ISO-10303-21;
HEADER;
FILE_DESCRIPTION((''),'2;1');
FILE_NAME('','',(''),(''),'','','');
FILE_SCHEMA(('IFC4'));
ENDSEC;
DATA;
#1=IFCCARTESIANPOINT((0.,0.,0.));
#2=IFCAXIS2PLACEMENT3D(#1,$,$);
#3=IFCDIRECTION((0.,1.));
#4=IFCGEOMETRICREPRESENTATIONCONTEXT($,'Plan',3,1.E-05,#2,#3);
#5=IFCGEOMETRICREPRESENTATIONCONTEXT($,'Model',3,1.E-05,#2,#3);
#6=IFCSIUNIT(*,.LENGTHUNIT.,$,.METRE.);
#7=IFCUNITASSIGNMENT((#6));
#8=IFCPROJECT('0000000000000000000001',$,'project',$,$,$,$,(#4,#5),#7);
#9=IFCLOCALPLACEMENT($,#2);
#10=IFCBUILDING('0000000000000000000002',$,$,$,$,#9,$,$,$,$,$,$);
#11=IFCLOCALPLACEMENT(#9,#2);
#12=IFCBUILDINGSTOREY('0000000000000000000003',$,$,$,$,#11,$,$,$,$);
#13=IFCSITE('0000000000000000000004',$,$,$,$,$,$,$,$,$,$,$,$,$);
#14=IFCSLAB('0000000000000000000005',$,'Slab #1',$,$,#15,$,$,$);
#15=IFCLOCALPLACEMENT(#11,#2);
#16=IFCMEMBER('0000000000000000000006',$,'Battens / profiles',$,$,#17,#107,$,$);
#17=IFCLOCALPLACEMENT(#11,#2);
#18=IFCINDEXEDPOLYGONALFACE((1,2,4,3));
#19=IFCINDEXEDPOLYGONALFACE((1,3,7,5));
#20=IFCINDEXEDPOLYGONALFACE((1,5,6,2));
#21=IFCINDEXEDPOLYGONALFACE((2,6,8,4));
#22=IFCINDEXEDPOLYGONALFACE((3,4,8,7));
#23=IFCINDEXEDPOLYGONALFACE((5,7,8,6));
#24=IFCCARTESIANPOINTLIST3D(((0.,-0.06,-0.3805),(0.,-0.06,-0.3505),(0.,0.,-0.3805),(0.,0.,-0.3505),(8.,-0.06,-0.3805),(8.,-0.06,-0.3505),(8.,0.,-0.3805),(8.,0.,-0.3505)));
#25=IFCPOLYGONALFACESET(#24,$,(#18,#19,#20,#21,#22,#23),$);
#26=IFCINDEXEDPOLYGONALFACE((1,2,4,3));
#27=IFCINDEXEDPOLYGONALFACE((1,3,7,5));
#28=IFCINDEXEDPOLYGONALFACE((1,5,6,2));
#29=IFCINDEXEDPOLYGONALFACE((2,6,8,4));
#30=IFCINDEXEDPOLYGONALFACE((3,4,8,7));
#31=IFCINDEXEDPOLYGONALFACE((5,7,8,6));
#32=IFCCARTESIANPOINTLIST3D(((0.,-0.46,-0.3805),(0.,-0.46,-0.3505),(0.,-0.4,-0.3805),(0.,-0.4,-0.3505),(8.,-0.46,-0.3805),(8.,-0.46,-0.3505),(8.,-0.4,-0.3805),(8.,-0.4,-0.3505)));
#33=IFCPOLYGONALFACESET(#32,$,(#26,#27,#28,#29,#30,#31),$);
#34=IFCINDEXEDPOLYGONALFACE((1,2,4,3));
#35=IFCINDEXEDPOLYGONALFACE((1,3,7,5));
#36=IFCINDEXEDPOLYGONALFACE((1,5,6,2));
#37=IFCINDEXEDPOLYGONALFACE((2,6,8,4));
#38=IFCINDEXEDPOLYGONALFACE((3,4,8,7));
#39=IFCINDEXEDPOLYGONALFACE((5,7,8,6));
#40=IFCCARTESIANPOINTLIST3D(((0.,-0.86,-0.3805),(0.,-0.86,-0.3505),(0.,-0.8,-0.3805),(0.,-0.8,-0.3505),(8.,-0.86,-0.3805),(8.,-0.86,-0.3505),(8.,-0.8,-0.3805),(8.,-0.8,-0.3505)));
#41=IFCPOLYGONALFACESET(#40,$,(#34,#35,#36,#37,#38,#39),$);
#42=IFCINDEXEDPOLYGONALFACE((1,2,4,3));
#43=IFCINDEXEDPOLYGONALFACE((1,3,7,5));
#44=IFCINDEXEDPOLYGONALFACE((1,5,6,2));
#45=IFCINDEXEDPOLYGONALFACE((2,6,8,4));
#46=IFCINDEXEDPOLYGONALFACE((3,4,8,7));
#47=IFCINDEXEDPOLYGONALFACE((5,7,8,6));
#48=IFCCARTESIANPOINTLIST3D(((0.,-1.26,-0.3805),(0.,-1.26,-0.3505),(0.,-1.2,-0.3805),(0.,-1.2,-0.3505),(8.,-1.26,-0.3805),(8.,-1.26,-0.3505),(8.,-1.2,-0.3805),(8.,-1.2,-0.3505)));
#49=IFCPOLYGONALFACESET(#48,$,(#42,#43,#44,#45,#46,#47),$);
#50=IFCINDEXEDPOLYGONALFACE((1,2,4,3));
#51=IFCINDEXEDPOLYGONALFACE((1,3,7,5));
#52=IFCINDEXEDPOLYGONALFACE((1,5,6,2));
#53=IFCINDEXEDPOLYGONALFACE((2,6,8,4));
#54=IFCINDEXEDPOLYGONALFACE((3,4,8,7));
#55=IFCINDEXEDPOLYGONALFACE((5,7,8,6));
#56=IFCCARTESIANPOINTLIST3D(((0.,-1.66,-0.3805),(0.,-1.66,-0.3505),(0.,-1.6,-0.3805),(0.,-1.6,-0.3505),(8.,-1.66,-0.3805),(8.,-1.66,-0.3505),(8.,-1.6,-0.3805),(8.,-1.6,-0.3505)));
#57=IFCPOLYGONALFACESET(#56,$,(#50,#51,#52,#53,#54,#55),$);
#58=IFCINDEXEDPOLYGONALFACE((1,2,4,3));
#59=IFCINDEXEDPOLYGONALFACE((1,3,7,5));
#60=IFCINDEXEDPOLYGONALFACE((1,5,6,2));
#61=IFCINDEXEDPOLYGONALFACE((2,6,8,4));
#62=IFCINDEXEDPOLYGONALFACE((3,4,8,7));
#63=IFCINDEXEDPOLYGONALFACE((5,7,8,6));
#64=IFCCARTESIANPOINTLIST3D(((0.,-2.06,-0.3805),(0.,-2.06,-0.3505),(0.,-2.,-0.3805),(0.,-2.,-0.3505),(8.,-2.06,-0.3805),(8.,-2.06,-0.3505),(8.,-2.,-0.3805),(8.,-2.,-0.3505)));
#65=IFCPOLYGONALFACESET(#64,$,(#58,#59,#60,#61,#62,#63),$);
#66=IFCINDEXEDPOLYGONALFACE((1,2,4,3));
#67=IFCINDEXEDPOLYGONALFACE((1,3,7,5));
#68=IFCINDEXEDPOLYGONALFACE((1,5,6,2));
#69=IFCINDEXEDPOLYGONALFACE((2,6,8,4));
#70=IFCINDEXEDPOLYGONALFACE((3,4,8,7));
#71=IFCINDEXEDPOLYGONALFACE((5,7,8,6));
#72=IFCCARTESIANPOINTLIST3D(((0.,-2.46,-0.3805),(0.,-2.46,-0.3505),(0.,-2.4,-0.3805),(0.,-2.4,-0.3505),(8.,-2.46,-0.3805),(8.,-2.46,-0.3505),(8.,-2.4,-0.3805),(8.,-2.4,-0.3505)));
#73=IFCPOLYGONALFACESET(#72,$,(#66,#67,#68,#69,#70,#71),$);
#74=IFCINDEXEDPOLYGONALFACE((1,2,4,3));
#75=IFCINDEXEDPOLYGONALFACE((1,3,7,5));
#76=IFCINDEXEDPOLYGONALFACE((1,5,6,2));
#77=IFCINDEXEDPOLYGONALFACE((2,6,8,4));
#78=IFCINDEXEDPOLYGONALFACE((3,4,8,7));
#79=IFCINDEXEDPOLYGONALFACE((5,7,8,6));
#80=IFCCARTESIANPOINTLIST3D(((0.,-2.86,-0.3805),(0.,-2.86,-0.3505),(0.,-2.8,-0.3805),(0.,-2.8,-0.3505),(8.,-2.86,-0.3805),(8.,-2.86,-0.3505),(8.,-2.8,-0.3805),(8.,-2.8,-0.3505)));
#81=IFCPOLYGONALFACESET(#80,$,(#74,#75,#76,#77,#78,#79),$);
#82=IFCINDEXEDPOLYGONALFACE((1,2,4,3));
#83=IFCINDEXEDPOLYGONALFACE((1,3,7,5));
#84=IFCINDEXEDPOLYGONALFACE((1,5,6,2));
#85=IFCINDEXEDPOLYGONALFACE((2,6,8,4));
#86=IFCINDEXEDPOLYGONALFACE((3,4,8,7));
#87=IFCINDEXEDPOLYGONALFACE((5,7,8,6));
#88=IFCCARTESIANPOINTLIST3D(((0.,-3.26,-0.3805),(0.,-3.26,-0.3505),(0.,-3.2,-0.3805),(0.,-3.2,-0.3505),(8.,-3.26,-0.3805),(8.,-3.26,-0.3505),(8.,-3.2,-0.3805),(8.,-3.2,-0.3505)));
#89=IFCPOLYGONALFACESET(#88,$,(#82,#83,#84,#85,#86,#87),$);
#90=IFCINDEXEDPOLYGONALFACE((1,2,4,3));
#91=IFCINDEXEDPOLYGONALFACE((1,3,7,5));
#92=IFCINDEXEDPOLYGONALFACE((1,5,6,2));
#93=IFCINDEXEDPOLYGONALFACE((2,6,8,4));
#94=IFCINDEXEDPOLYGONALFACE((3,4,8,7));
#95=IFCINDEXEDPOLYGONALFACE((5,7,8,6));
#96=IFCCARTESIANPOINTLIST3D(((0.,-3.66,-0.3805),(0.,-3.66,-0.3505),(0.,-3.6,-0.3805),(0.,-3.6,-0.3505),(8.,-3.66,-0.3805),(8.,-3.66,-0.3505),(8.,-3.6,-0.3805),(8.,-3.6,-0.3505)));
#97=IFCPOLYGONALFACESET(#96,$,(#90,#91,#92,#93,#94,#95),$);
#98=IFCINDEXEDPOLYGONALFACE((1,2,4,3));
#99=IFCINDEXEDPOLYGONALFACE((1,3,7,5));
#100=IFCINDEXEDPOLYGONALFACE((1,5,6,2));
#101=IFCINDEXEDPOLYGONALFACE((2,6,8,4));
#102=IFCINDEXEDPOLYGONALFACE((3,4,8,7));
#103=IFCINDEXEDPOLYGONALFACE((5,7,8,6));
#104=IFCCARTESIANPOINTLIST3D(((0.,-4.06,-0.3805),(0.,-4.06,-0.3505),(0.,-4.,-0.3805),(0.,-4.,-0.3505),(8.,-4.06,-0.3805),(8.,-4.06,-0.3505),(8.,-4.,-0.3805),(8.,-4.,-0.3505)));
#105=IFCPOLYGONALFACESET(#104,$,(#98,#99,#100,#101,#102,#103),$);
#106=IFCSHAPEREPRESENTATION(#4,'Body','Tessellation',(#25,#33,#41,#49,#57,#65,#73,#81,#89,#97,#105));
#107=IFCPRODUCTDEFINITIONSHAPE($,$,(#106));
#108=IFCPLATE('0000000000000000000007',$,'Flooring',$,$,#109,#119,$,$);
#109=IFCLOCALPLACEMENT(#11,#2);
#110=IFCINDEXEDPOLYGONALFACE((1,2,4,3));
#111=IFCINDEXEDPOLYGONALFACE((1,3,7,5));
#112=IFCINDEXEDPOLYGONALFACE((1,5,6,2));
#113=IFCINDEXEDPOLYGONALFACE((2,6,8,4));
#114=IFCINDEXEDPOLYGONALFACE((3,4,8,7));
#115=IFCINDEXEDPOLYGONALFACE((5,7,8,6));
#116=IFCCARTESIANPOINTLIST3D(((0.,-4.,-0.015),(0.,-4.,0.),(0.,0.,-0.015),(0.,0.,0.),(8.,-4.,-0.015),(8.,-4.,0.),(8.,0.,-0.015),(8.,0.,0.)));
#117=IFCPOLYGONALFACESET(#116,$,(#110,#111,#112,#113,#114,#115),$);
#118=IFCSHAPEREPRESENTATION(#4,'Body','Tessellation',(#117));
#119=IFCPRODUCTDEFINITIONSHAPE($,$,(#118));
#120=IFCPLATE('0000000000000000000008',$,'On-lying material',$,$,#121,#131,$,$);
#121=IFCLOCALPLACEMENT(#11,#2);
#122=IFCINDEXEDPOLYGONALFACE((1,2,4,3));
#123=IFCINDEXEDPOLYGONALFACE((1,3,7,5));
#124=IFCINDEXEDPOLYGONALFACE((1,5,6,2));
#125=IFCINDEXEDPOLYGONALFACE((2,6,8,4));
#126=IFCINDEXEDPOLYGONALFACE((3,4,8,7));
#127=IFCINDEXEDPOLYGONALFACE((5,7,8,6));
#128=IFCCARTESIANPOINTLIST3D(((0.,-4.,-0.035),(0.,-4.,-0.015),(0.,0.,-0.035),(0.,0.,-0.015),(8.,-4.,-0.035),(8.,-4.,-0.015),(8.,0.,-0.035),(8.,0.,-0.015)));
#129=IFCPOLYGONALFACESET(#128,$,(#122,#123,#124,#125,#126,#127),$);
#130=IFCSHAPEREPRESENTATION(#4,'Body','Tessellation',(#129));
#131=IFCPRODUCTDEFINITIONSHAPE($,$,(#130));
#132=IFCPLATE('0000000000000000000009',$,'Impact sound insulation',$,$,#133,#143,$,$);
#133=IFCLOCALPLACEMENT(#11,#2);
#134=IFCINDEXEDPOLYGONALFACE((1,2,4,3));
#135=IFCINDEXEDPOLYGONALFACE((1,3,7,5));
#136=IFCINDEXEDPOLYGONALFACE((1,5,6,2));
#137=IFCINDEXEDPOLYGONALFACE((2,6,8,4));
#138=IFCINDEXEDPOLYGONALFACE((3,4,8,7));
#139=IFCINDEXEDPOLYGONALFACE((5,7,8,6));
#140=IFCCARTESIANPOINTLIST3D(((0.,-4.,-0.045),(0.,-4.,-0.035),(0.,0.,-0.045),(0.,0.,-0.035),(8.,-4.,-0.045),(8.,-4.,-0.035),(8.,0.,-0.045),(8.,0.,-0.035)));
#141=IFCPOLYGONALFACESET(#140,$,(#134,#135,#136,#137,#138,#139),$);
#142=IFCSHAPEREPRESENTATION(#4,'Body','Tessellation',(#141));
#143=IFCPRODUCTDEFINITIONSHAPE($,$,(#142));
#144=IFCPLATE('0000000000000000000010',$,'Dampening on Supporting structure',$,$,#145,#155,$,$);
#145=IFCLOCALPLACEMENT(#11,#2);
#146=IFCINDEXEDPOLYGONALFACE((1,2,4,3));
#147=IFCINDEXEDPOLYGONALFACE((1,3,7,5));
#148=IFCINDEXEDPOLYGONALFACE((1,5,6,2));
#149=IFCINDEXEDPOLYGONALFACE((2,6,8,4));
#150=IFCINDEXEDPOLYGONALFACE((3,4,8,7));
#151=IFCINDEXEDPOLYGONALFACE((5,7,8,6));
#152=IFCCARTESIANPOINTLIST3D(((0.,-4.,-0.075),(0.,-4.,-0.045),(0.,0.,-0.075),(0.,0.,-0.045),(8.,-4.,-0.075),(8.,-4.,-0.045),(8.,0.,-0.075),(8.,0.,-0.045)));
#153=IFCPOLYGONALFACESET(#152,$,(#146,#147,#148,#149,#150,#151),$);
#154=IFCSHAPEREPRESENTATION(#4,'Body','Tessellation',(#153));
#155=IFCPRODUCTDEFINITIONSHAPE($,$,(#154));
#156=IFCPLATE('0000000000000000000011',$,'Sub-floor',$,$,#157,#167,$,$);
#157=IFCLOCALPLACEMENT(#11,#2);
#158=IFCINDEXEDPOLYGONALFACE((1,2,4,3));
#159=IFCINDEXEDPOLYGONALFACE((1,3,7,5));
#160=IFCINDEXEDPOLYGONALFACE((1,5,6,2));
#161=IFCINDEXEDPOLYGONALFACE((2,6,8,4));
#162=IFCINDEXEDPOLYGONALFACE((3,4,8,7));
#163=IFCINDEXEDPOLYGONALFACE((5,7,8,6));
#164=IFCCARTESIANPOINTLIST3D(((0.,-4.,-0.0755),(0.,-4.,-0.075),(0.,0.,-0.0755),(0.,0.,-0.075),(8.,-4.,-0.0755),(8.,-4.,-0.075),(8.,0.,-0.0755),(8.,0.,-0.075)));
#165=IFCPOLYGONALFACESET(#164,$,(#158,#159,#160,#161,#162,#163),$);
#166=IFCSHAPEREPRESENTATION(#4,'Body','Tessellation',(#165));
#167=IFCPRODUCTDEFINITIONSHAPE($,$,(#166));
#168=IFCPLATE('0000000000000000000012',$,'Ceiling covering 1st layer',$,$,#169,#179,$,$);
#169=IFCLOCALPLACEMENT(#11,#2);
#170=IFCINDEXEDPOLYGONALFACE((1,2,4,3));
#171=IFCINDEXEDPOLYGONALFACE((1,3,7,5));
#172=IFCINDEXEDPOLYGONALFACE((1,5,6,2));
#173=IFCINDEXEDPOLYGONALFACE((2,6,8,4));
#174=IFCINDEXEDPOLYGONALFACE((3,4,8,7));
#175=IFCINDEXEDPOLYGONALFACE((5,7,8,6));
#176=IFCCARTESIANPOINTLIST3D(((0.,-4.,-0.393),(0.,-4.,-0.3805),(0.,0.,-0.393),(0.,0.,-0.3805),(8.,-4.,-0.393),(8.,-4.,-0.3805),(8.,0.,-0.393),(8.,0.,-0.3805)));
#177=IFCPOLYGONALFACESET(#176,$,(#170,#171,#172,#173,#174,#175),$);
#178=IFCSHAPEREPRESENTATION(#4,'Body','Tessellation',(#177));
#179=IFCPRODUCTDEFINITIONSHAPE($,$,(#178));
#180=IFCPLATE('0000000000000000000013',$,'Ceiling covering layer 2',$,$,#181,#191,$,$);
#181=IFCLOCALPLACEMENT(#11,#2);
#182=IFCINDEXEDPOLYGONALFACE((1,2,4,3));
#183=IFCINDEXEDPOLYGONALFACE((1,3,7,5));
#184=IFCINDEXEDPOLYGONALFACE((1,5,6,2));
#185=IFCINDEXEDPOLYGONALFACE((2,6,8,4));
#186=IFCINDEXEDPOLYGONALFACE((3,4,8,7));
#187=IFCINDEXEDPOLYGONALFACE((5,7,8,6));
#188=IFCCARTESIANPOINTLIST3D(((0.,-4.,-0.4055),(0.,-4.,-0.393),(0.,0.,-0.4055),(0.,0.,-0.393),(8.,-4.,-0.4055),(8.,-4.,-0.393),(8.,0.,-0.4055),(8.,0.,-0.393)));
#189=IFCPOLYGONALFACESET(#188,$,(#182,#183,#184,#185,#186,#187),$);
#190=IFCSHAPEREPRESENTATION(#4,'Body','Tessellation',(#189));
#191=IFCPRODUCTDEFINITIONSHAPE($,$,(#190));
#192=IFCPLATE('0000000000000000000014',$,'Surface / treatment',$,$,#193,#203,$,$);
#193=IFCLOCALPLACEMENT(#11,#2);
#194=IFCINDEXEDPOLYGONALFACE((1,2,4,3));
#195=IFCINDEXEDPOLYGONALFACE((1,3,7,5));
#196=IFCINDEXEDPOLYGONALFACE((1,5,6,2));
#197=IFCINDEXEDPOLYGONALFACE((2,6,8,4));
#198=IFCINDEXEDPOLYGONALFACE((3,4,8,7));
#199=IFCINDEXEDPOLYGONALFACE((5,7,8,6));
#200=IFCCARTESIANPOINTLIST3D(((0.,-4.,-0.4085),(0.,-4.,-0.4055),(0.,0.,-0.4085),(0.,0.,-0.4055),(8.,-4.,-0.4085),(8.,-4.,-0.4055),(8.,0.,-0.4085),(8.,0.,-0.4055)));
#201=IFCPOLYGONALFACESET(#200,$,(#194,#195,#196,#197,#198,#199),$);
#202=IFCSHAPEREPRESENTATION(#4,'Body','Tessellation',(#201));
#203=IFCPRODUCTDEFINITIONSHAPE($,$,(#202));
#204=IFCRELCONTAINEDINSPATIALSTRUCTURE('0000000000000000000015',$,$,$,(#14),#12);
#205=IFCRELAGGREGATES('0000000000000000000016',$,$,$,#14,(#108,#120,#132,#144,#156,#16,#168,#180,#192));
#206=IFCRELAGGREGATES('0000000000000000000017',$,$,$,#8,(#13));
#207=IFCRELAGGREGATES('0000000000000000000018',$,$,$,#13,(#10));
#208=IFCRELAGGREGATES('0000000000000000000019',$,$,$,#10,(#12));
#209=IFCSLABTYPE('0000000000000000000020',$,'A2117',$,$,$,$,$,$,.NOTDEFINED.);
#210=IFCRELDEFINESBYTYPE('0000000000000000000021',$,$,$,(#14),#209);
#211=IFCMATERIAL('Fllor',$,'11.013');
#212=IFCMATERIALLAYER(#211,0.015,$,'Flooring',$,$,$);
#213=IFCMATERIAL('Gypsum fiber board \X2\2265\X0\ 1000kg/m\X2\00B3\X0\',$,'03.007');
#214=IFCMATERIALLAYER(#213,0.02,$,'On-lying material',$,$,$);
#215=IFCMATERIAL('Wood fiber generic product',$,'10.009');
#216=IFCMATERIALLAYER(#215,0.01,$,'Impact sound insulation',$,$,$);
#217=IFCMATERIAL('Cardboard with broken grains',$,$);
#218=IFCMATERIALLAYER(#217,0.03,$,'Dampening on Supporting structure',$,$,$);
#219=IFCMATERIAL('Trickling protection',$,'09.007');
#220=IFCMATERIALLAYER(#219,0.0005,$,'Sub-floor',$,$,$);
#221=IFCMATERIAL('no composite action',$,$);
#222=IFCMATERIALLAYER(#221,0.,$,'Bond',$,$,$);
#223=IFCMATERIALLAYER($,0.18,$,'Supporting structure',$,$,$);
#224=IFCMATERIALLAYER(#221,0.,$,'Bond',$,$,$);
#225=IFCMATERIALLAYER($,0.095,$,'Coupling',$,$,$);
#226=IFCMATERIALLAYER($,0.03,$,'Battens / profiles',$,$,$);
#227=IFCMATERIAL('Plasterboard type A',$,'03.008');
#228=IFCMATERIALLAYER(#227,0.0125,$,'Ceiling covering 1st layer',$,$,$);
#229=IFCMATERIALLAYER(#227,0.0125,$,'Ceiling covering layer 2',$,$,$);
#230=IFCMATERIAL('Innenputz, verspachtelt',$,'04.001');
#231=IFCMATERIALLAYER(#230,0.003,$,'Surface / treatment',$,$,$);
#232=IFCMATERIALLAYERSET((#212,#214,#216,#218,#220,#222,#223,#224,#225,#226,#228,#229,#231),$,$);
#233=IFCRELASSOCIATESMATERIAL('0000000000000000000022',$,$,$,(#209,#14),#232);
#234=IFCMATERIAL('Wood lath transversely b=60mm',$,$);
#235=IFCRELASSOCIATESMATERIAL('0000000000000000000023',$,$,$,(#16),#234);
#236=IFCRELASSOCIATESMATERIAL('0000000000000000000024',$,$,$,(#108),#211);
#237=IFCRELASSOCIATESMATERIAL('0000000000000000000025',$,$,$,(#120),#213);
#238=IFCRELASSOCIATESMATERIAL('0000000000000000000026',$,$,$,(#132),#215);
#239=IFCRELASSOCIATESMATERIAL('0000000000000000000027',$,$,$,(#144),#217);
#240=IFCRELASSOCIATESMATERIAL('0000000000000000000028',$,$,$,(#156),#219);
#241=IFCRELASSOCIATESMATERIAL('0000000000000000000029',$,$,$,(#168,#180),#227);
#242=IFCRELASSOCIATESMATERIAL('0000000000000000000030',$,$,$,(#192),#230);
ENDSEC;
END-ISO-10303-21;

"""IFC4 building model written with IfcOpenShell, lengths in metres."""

from ifc_helpers import new_model, si_unit, direction, frame, frame_2d, origin, origin_with_axes, place, context, project, spatial, rectangle, extrude, material, layer, layer_set, type_object, element, aggregate, save


model = new_model("IFC4")

# Units and contexts
plan_context = context("Plan", 3, precision=1e-05, world=origin(), true_north=direction((0.0, 1.0)))
model_context = context("Model", 3, precision=1e-05, world=origin(), true_north=direction((0.0, 1.0)))
ifc_project = project(units=[si_unit("LENGTHUNIT", "METRE")], contexts=[plan_context, model_context])

# Site, building, storey
site = spatial("IfcSite", under=ifc_project)
building_placement = place(None, origin())
building = spatial("IfcBuilding", under=site, at=building_placement)
storey_placement = place(building_placement, origin())
storey = spatial("IfcBuildingStorey", under=building, at=storey_placement)

# Slab, member, plates
ifc_material_1 = material(Name="Fllor", Category="11.013")
ifc_layer_1 = layer(ifc_material_1, 0.015, Name="Flooring")
ifc_material_2 = material(Name="Gypsum fiber board ≥ 1000kg/m³", Category="03.007")
ifc_layer_2 = layer(ifc_material_2, 0.02, Name="On-lying material")
ifc_material_3 = material(Name="Wood fiber generic product", Category="10.009")
ifc_layer_3 = layer(ifc_material_3, 0.01, Name="Impact sound insulation")
ifc_material_4 = material(Name="Cardboard with broken grains")
ifc_layer_4 = layer(ifc_material_4, 0.03, Name="Dampening on Supporting structure")
ifc_material_5 = material(Name="Trickling protection", Category="09.007")
ifc_layer_5 = layer(ifc_material_5, 0.0005, Name="Sub-floor")
ifc_material_6 = material(Name="no composite action")
ifc_layer_6 = layer(ifc_material_6, 0.0, Name="Bond")
ifc_layer_7 = layer(None, 0.18, Name="Supporting structure")
ifc_layer_8 = layer(ifc_material_6, 0.0, Name="Bond")
ifc_layer_9 = layer(None, 0.095, Name="Coupling")
ifc_layer_10 = layer(None, 0.03, Name="Battens / profiles")
ifc_material_7 = material(Name="Plasterboard type A", Category="03.008")
ifc_layer_11 = layer(ifc_material_7, 0.0125, Name="Ceiling covering 1st layer")
ifc_layer_12 = layer(ifc_material_7, 0.0125, Name="Ceiling covering layer 2")
ifc_material_8 = material(Name="Innenputz, verspachtelt", Category="04.001")
ifc_layer_13 = layer(ifc_material_8, 0.003, Name="Surface / treatment")
ifc_layer_set = layer_set([ifc_layer_1, ifc_layer_2, ifc_layer_3, ifc_layer_4, ifc_layer_5, ifc_layer_6, ifc_layer_7, ifc_layer_8, ifc_layer_9, ifc_layer_10, ifc_layer_11, ifc_layer_12, ifc_layer_13])
slab_type = type_object("IfcSlabType", Name="A2117", PredefinedType="NOTDEFINED", material=ifc_layer_set)
slab_placement = place(None, frame((0.0, 0.0, 0.0), z_axis=(0.0, 0.0, -1.0), x_axis=(1.0, 0.0, 0.0)))
slab = element("IfcSlab", 1, at=slab_placement, inside=storey, type_object=slab_type, material=ifc_layer_set, Name="Slab #1")
ifc_material_9 = material(Name="Wood lath transversely b=60mm")
member_1_placement = place(slab_placement, origin())
member_1 = element("IfcMember", 2, at=member_1_placement, material=ifc_material_9, Name="Battens / profiles", context=plan_context, shape_type="SweptSolid", body=[
    extrude(rectangle(XDim=0.06, YDim=0.03, at=frame_2d((0.03, 0.015), x_axis=(1.0, 0.0))), frame((0.0, 0.0, 0.3505), z_axis=(1.0, 0.0, 0.0), x_axis=(0.0, 1.0, 0.0)), (0.0, 0.0, 1.0), 8.0),
    extrude(rectangle(XDim=0.06, YDim=0.03, at=frame_2d((0.03, 0.015), x_axis=(1.0, 0.0))), frame((0.0, 0.4, 0.3505), z_axis=(1.0, 0.0, 0.0), x_axis=(0.0, 1.0, 0.0)), (0.0, 0.0, 1.0), 8.0),
    extrude(rectangle(XDim=0.06, YDim=0.03, at=frame_2d((0.03, 0.015), x_axis=(1.0, 0.0))), frame((0.0, 0.8, 0.3505), z_axis=(1.0, 0.0, 0.0), x_axis=(0.0, 1.0, 0.0)), (0.0, 0.0, 1.0), 8.0),
    extrude(rectangle(XDim=0.06, YDim=0.03, at=frame_2d((0.03, 0.015), x_axis=(1.0, 0.0))), frame((0.0, 1.2, 0.3505), z_axis=(1.0, 0.0, 0.0), x_axis=(0.0, 1.0, 0.0)), (0.0, 0.0, 1.0), 8.0),
    extrude(rectangle(XDim=0.06, YDim=0.03, at=frame_2d((0.03, 0.015), x_axis=(1.0, 0.0))), frame((0.0, 1.6, 0.3505), z_axis=(1.0, 0.0, 0.0), x_axis=(0.0, 1.0, 0.0)), (0.0, 0.0, 1.0), 8.0),
    extrude(rectangle(XDim=0.06, YDim=0.03, at=frame_2d((0.03, 0.015), x_axis=(1.0, 0.0))), frame((0.0, 2.0, 0.3505), z_axis=(1.0, 0.0, 0.0), x_axis=(0.0, 1.0, 0.0)), (0.0, 0.0, 1.0), 8.0),
    extrude(rectangle(XDim=0.06, YDim=0.03, at=frame_2d((0.03, 0.015), x_axis=(1.0, 0.0))), frame((0.0, 2.4, 0.3505), z_axis=(1.0, 0.0, 0.0), x_axis=(0.0, 1.0, 0.0)), (0.0, 0.0, 1.0), 8.0),
    extrude(rectangle(XDim=0.06, YDim=0.03, at=frame_2d((0.03, 0.015), x_axis=(1.0, 0.0))), frame((0.0, 2.8, 0.3505), z_axis=(1.0, 0.0, 0.0), x_axis=(0.0, 1.0, 0.0)), (0.0, 0.0, 1.0), 8.0),
    extrude(rectangle(XDim=0.06, YDim=0.03, at=frame_2d((0.03, 0.015), x_axis=(1.0, 0.0))), frame((0.0, 3.2, 0.3505), z_axis=(1.0, 0.0, 0.0), x_axis=(0.0, 1.0, 0.0)), (0.0, 0.0, 1.0), 8.0),
    extrude(rectangle(XDim=0.06, YDim=0.03, at=frame_2d((0.03, 0.015), x_axis=(1.0, 0.0))), frame((0.0, 3.6, 0.3505), z_axis=(1.0, 0.0, 0.0), x_axis=(0.0, 1.0, 0.0)), (0.0, 0.0, 1.0), 8.0),
    extrude(rectangle(XDim=0.06, YDim=0.03, at=frame_2d((0.03, 0.015), x_axis=(1.0, 0.0))), frame((0.0, 4.0, 0.3505), z_axis=(1.0, 0.0, 0.0), x_axis=(0.0, 1.0, 0.0)), (0.0, 0.0, 1.0), 8.0),
])
plate_1_placement = place(slab_placement, origin())
plate_1 = element("IfcPlate", 3, at=plate_1_placement, material=ifc_material_1, Name="Flooring", context=plan_context, shape_type="SweptSolid", body=[
    extrude(rectangle(XDim=8.0, YDim=4.0, at=frame_2d((4.0, 2.0), x_axis=(1.0, 0.0))), origin_with_axes(), (0.0, 0.0, 1.0), 0.015),
])
plate_2_placement = place(slab_placement, origin())
plate_2 = element("IfcPlate", 4, at=plate_2_placement, material=ifc_material_2, Name="On-lying material", context=plan_context, shape_type="SweptSolid", body=[
    extrude(rectangle(XDim=8.0, YDim=4.0, at=frame_2d((4.0, 2.0), x_axis=(1.0, 0.0))), frame((0.0, 0.0, 0.015), z_axis=(0.0, 0.0, 1.0), x_axis=(1.0, 0.0, 0.0)), (0.0, 0.0, 1.0), 0.02),
])
plate_3_placement = place(slab_placement, origin())
plate_3 = element("IfcPlate", 5, at=plate_3_placement, material=ifc_material_3, Name="Impact sound insulation", context=plan_context, shape_type="SweptSolid", body=[
    extrude(rectangle(XDim=8.0, YDim=4.0, at=frame_2d((4.0, 2.0), x_axis=(1.0, 0.0))), frame((0.0, 0.0, 0.035), z_axis=(0.0, 0.0, 1.0), x_axis=(1.0, 0.0, 0.0)), (0.0, 0.0, 1.0), 0.01),
])
plate_4_placement = place(slab_placement, origin())
plate_4 = element("IfcPlate", 6, at=plate_4_placement, material=ifc_material_4, Name="Dampening on Supporting structure", context=plan_context, shape_type="SweptSolid", body=[
    extrude(rectangle(XDim=8.0, YDim=4.0, at=frame_2d((4.0, 2.0), x_axis=(1.0, 0.0))), frame((0.0, 0.0, 0.045), z_axis=(0.0, 0.0, 1.0), x_axis=(1.0, 0.0, 0.0)), (0.0, 0.0, 1.0), 0.03),
])
plate_5_placement = place(slab_placement, origin())
plate_5 = element("IfcPlate", 7, at=plate_5_placement, material=ifc_material_5, Name="Sub-floor", context=plan_context, shape_type="SweptSolid", body=[
    extrude(rectangle(XDim=8.0, YDim=4.0, at=frame_2d((4.0, 2.0), x_axis=(1.0, 0.0))), frame((0.0, 0.0, 0.075), z_axis=(0.0, 0.0, 1.0), x_axis=(1.0, 0.0, 0.0)), (0.0, 0.0, 1.0), 0.0005),
])
plate_6_placement = place(slab_placement, origin())
plate_6 = element("IfcPlate", 8, at=plate_6_placement, material=ifc_material_7, Name="Ceiling covering 1st layer", context=plan_context, shape_type="SweptSolid", body=[
    extrude(rectangle(XDim=8.0, YDim=4.0, at=frame_2d((4.0, 2.0), x_axis=(1.0, 0.0))), frame((0.0, 0.0, 0.3805), z_axis=(0.0, 0.0, 1.0), x_axis=(1.0, 0.0, 0.0)), (0.0, 0.0, 1.0), 0.0125),
])
plate_7_placement = place(slab_placement, origin())
plate_7 = element("IfcPlate", 9, at=plate_7_placement, material=ifc_material_7, Name="Ceiling covering layer 2", context=plan_context, shape_type="SweptSolid", body=[
    extrude(rectangle(XDim=8.0, YDim=4.0, at=frame_2d((4.0, 2.0), x_axis=(1.0, 0.0))), frame((0.0, 0.0, 0.393), z_axis=(0.0, 0.0, 1.0), x_axis=(1.0, 0.0, 0.0)), (0.0, 0.0, 1.0), 0.0125),
])
plate_8_placement = place(slab_placement, origin())
plate_8 = element("IfcPlate", 10, at=plate_8_placement, material=ifc_material_8, Name="Surface / treatment", context=plan_context, shape_type="SweptSolid", body=[
    extrude(rectangle(XDim=8.0, YDim=4.0, at=frame_2d((4.0, 2.0), x_axis=(1.0, 0.0))), frame((0.0, 0.0, 0.4055), z_axis=(0.0, 0.0, 1.0), x_axis=(1.0, 0.0, 0.0)), (0.0, 0.0, 1.0), 0.003),
])
aggregate(slab, [plate_1, plate_2, plate_3, plate_4, plate_5, member_1, plate_6, plate_7, plate_8])

save(model, "model.ifc")
